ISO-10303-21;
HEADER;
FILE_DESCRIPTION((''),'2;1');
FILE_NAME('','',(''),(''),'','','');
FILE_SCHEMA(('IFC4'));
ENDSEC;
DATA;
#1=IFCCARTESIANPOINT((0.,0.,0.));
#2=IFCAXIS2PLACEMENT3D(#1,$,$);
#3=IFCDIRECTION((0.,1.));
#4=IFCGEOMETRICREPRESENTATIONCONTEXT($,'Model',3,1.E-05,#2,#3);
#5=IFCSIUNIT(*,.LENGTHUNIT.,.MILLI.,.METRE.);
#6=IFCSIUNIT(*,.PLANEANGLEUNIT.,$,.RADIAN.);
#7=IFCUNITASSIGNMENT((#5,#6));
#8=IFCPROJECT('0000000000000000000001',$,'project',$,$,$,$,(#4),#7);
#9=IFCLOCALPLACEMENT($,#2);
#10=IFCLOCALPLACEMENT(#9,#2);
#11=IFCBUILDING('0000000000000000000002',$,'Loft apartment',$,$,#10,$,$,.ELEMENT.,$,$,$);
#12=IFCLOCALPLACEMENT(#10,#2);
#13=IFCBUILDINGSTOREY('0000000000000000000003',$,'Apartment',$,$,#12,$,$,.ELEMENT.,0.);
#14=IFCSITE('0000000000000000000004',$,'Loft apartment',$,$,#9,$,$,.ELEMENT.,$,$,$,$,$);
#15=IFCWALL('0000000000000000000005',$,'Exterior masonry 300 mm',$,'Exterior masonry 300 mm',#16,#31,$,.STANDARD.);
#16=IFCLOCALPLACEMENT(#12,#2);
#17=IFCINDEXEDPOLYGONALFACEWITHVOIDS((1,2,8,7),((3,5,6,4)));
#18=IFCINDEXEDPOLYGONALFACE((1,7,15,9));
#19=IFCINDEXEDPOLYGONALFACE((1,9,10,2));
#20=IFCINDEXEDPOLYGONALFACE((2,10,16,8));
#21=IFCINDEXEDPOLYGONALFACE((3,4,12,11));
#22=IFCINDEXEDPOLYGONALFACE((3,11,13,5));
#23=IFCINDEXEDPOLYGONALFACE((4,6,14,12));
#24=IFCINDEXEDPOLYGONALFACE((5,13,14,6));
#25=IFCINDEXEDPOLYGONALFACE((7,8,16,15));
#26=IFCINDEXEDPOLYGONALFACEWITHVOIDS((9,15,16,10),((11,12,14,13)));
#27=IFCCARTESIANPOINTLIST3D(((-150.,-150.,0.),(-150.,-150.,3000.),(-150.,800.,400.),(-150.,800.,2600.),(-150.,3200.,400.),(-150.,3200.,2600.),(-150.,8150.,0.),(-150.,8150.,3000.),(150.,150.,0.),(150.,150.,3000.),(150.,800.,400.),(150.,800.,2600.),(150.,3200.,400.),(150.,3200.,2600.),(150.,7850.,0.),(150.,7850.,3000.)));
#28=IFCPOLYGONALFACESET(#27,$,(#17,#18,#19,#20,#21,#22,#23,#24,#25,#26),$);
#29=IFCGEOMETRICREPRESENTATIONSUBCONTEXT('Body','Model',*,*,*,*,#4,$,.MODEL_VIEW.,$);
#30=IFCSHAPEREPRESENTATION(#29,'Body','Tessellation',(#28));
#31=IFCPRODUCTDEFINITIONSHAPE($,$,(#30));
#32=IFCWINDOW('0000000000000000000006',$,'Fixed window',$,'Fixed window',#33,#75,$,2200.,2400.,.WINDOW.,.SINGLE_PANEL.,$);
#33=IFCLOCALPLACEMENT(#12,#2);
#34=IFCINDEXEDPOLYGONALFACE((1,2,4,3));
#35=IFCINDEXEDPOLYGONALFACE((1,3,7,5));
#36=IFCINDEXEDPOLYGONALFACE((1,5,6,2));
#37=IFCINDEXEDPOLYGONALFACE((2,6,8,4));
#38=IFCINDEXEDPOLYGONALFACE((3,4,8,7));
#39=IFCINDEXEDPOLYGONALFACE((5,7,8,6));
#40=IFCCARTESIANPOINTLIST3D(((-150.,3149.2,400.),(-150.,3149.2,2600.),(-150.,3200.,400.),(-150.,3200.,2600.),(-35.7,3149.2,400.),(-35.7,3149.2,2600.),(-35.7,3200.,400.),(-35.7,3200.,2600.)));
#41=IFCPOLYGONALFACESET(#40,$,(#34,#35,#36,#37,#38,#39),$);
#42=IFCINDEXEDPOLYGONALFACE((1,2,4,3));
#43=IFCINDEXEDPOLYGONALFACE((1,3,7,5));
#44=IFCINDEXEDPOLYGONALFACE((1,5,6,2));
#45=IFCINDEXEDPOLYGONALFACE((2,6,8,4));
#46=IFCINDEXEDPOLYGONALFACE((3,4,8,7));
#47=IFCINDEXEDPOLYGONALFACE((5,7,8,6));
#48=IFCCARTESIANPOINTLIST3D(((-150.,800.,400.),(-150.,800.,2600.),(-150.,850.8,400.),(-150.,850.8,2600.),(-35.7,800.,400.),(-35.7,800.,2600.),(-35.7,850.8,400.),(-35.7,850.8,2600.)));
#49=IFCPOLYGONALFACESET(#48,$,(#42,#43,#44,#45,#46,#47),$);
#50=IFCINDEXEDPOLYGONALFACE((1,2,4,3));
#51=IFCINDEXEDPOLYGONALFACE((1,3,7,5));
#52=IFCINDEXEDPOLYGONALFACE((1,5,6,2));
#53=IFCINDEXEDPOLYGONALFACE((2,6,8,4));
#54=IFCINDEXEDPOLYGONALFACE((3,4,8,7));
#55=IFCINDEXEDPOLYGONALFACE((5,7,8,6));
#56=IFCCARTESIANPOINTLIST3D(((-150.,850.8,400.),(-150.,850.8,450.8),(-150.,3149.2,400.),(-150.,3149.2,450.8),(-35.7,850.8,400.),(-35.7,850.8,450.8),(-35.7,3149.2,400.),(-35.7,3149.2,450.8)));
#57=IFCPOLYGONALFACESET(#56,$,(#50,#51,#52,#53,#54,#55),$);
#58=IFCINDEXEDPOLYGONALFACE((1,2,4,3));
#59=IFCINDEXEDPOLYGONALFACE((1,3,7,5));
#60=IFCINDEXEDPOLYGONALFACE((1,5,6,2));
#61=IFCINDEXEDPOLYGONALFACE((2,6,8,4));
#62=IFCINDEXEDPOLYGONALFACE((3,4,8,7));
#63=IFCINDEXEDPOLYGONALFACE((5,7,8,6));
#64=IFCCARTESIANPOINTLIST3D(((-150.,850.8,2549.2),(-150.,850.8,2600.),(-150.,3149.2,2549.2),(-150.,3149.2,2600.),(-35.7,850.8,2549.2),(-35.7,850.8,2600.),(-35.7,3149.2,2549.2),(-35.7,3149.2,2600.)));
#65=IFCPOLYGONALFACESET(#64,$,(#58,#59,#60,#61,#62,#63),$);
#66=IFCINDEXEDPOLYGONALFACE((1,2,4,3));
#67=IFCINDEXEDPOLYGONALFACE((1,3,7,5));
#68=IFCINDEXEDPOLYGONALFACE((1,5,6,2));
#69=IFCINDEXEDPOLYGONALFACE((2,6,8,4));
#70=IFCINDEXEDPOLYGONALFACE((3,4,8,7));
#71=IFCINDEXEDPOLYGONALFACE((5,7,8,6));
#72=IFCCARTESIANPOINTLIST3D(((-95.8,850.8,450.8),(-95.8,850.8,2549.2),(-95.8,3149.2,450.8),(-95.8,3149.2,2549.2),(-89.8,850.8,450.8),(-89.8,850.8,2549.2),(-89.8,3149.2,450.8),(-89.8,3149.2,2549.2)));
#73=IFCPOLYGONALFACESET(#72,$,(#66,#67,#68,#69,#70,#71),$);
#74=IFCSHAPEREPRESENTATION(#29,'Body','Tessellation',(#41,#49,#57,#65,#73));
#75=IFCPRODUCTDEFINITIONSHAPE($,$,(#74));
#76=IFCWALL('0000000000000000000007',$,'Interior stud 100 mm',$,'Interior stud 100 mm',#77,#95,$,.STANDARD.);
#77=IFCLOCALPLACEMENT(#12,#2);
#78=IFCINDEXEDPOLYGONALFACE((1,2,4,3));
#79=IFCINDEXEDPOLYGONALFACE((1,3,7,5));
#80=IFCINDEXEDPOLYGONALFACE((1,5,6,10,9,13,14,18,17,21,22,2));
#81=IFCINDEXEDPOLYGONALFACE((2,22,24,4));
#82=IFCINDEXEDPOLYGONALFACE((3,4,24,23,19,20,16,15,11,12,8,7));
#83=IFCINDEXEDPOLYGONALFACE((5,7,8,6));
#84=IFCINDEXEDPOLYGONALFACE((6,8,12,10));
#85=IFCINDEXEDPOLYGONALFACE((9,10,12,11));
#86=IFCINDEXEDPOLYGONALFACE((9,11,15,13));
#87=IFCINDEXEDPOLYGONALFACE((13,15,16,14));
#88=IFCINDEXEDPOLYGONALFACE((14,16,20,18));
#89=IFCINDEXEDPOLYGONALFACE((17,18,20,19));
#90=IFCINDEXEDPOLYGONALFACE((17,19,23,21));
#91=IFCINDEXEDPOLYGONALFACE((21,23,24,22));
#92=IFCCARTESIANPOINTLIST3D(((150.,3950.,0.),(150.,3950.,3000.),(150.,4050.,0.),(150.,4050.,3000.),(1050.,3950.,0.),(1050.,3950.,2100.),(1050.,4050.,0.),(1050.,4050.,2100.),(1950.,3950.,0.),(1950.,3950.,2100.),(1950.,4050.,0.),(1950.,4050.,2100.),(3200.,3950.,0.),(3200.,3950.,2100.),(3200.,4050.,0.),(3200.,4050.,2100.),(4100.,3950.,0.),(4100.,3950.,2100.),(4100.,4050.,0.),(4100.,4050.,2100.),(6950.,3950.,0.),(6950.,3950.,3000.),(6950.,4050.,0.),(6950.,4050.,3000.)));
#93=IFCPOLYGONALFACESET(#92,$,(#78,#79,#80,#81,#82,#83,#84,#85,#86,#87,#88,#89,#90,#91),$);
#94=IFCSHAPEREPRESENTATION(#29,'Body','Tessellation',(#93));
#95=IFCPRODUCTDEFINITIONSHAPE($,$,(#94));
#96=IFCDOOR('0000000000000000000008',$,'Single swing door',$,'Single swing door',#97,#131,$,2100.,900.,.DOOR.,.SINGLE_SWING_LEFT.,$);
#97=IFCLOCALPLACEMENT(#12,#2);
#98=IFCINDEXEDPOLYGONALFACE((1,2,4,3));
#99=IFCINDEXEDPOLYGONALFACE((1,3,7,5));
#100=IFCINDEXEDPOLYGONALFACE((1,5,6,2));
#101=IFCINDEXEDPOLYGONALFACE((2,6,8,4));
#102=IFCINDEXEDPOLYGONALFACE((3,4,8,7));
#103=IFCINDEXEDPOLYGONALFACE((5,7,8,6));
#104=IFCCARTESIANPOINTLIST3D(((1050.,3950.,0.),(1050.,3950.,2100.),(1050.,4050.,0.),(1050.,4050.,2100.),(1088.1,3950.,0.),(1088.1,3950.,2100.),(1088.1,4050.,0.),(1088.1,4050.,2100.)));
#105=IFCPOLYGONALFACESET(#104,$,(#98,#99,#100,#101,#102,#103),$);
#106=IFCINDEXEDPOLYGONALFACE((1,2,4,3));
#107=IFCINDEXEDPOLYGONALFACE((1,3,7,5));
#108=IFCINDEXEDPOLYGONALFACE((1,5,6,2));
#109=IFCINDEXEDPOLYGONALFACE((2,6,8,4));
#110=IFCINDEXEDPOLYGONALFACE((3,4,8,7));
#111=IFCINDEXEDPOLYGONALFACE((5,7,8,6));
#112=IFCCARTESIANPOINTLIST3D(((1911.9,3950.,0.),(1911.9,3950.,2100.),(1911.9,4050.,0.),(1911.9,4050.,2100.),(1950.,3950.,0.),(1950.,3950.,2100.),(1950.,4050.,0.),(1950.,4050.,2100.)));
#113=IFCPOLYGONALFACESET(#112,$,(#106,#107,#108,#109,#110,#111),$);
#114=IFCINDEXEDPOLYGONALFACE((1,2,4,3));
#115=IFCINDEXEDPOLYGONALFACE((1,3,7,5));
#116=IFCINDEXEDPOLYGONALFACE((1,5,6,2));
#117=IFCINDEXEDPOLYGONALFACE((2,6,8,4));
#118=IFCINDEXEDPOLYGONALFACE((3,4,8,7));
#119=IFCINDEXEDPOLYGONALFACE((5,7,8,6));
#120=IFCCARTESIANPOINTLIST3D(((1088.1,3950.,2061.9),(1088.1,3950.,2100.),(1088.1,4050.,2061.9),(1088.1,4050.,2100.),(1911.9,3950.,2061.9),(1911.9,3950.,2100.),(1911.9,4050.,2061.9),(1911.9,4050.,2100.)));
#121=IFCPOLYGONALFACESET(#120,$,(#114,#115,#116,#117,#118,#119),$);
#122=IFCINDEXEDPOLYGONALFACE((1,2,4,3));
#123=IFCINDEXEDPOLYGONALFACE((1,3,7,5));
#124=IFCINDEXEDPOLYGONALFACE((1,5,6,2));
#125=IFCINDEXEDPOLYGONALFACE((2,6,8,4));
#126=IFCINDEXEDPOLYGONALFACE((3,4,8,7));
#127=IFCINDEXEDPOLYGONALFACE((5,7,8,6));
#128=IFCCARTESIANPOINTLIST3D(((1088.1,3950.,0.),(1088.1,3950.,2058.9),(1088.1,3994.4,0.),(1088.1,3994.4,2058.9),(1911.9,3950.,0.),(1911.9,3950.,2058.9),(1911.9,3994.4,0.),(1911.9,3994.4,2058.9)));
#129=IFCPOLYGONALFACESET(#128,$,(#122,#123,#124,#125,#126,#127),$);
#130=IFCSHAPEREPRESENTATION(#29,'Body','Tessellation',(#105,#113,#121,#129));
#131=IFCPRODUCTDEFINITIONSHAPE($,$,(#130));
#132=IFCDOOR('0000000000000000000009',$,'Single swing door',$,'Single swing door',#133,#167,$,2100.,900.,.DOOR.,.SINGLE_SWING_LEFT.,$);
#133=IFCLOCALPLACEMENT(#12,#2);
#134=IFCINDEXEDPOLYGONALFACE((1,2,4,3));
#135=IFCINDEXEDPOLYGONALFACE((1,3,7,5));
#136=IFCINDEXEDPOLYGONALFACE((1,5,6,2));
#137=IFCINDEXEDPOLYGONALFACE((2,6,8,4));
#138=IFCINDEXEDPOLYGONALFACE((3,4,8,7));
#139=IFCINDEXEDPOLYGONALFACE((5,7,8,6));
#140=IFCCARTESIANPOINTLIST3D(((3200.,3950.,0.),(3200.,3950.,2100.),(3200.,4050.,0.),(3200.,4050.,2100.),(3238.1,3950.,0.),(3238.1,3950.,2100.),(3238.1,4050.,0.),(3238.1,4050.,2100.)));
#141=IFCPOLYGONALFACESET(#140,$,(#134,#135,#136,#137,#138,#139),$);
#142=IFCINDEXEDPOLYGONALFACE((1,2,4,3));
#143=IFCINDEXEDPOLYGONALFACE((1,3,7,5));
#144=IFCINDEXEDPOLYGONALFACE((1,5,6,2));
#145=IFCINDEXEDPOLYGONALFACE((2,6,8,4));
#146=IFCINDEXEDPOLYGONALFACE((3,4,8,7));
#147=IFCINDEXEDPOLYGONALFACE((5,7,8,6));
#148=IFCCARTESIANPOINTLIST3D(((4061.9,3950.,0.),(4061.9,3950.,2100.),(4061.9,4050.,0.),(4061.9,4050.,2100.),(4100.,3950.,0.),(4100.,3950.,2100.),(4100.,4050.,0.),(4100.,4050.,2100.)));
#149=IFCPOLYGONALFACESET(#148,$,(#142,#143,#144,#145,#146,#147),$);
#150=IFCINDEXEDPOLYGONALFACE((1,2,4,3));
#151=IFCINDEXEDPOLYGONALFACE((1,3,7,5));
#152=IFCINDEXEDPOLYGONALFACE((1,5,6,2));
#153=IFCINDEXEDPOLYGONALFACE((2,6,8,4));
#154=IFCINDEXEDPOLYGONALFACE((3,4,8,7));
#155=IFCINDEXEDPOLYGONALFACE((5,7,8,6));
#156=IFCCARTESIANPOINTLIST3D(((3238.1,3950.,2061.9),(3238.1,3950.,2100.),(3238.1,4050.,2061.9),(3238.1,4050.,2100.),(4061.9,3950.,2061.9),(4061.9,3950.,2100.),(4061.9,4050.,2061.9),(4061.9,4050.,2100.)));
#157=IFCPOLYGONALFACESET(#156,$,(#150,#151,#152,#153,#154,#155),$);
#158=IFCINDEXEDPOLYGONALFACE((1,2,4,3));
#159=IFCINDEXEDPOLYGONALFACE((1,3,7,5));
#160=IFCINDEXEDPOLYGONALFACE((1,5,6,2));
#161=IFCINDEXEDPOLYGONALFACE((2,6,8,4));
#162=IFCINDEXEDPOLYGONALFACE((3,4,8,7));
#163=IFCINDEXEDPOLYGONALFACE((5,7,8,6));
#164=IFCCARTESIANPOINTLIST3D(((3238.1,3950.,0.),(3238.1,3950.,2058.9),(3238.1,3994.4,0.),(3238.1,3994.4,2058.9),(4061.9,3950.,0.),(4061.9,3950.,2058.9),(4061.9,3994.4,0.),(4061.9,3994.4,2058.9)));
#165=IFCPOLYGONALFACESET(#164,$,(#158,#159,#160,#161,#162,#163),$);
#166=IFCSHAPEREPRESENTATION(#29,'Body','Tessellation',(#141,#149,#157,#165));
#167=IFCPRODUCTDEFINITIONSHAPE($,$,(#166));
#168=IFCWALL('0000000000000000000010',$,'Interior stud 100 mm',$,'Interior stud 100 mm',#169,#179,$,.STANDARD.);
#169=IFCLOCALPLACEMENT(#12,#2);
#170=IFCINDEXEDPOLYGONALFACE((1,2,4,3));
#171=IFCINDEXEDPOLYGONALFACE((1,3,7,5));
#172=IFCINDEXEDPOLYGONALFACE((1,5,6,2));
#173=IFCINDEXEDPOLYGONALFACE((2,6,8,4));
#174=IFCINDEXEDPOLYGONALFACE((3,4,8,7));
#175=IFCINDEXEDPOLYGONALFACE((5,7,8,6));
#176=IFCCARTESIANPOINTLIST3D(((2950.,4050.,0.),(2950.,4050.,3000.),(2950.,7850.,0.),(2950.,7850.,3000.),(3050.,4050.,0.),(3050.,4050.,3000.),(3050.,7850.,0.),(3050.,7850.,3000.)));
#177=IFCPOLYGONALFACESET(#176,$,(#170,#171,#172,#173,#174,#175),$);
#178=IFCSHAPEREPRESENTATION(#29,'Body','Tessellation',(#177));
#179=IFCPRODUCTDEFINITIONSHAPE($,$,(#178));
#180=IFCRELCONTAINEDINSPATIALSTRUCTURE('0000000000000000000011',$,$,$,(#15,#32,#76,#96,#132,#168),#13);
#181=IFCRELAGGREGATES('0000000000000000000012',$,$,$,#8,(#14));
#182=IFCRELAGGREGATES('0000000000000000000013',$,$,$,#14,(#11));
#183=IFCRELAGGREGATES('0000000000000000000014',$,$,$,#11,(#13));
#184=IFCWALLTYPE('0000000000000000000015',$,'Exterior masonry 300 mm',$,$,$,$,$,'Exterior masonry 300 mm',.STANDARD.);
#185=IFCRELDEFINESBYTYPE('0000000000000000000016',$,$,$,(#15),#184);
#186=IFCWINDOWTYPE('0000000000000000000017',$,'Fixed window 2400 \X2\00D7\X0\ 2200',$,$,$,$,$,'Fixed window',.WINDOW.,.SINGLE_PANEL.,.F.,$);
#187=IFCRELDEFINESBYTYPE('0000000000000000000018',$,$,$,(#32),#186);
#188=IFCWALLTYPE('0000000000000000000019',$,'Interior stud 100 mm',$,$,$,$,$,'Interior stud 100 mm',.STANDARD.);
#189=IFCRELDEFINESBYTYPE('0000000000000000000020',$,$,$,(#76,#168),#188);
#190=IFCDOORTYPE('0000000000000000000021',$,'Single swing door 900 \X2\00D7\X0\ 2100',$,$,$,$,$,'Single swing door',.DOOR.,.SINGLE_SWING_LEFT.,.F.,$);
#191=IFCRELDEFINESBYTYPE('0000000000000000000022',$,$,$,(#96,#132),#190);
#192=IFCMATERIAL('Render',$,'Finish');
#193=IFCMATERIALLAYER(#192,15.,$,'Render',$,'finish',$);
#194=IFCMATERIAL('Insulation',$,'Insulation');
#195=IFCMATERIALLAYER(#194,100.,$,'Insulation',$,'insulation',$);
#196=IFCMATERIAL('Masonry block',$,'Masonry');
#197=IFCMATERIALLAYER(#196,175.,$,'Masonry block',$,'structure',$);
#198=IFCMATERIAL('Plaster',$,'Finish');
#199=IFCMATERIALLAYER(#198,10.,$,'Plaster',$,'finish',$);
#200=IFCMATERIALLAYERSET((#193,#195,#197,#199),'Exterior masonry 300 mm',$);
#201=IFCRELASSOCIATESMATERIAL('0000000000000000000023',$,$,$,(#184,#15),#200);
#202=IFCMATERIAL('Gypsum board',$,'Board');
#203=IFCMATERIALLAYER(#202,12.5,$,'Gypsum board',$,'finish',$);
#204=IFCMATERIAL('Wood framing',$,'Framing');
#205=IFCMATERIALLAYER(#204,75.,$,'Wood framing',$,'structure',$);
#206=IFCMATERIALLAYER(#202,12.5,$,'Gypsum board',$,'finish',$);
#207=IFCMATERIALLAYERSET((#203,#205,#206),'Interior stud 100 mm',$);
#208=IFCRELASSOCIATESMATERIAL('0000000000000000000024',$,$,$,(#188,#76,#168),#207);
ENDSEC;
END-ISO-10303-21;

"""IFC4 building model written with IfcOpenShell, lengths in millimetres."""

from ifc_helpers import new_model, si_unit, direction, frame, origin, origin_with_axes, place, context, subcontext, project, spatial, polyline, outline, extrude, material, layer, layer_set, layer_usage, type_object, element, fill, save


model = new_model("IFC4")

# Units and contexts
model_context = context("Model", 3, precision=1e-05, world=origin(), true_north=direction((0.0, 1.0)))
body_context = subcontext(model_context, "Body", "Model", "MODEL_VIEW")
ifc_project = project(units=[si_unit("LENGTHUNIT", "METRE", prefix="MILLI"), si_unit("PLANEANGLEUNIT", "RADIAN")], contexts=[model_context])

# Site, building, storey
site_placement = place(None, origin())
site = spatial("IfcSite", under=ifc_project, at=site_placement, Name="Loft apartment", CompositionType="ELEMENT")
building_placement = place(site_placement, origin())
building = spatial("IfcBuilding", under=site, at=building_placement, Name="Loft apartment", CompositionType="ELEMENT")
storey_placement = place(building_placement, origin())
storey = spatial("IfcBuildingStorey", under=building, at=storey_placement, Name="Apartment", CompositionType="ELEMENT", Elevation=0.0)

# Shared definitions
ifc_material_1 = material(Name="Render", Category="Finish")
ifc_layer_1 = layer(ifc_material_1, 15.0, Name="Render", Category="finish")
ifc_material_2 = material(Name="Insulation", Category="Insulation")
ifc_layer_2 = layer(ifc_material_2, 100.0, Name="Insulation", Category="insulation")
ifc_material_3 = material(Name="Masonry block", Category="Masonry")
ifc_layer_3 = layer(ifc_material_3, 175.0, Name="Masonry block", Category="structure")
ifc_material_4 = material(Name="Plaster", Category="Finish")
ifc_layer_4 = layer(ifc_material_4, 10.0, Name="Plaster", Category="finish")
ifc_layer_set_1 = layer_set([ifc_layer_1, ifc_layer_2, ifc_layer_3, ifc_layer_4], Name="Exterior masonry 300 mm")
wall_type_1 = type_object("IfcWallType", Name="Exterior masonry 300 mm", ElementType="Exterior masonry 300 mm", PredefinedType="STANDARD", material=ifc_layer_set_1)

# Wall, opening, window
ifc_layer_usage_1 = layer_usage(ifc_layer_set_1, "AXIS2", "POSITIVE", -150.0)
wall_1_placement = place(storey_placement, frame((0.0, 8000.0, 0.0), z_axis=(0.0, 0.0, 1.0), x_axis=(0.0, -1.0, 0.0)))
wall_1 = element("IfcWall", 1, at=wall_1_placement, inside=storey, type_object=wall_type_1, material=ifc_layer_usage_1, Name="Exterior masonry 300 mm", ObjectType="Exterior masonry 300 mm", PredefinedType="STANDARD", context=body_context, shape_type="SweptSolid", body=[
    extrude(outline(polyline([(-150.0, -150.0), (8150.0, -150.0), (7850.0, 150.0), (150.0, 150.0), (-150.0, -150.0)])), origin(), (0.0, 0.0, 1.0), 3000.0),
])
opening_1_placement = place(wall_1_placement, frame((4800.0, 0.0, 400.0), z_axis=(0.0, 0.0, 1.0), x_axis=(1.0, 0.0, 0.0)))
opening_1 = element("IfcOpeningElement", 2, at=opening_1_placement, cuts=wall_1, PredefinedType="OPENING", context=body_context, shape_type="SweptSolid", body=[
    extrude(outline(polyline([(0.0, -160.0), (2400.0, -160.0), (2400.0, 160.0), (0.0, 160.0), (0.0, -160.0)])), origin(), (0.0, 0.0, 1.0), 2200.0),
])
window_type_1 = type_object("IfcWindowType", Name="Fixed window 2400 × 2200", ElementType="Fixed window", ParameterTakesPrecedence=False, PartitioningType="SINGLE_PANEL", PredefinedType="WINDOW")
window_1_placement = place(opening_1_placement, origin_with_axes())
window_1 = element("IfcWindow", 3, at=window_1_placement, inside=storey, type_object=window_type_1, Name="Fixed window", ObjectType="Fixed window", OverallHeight=2200.0, OverallWidth=2400.0, PartitioningType="SINGLE_PANEL", PredefinedType="WINDOW", context=body_context, shape_type="SweptSolid", body=[
    extrude(outline(polyline([(0.0, -150.0), (50.8, -150.0), (50.8, -35.7), (0.0, -35.7), (0.0, -150.0)])), origin(), (0.0, 0.0, 1.0), 2200.0),
    extrude(outline(polyline([(2349.2, -150.0), (2400.0, -150.0), (2400.0, -35.7), (2349.2, -35.7), (2349.2, -150.0)])), origin(), (0.0, 0.0, 1.0), 2200.0),
    extrude(outline(polyline([(50.8, -150.0), (2349.2, -150.0), (2349.2, -35.7), (50.8, -35.7), (50.8, -150.0)])), origin(), (0.0, 0.0, 1.0), 50.8),
    extrude(outline(polyline([(50.8, -150.0), (2349.2, -150.0), (2349.2, -35.7), (50.8, -35.7), (50.8, -150.0)])), frame((0.0, 0.0, 2149.2)), (0.0, 0.0, 1.0), 50.8),
    extrude(outline(polyline([(50.8, -95.8), (2349.2, -95.8), (2349.2, -89.8), (50.8, -89.8), (50.8, -95.8)])), frame((0.0, 0.0, 50.8)), (0.0, 0.0, 1.0), 2098.4),
])
fill(opening_1, window_1)

# Wall, openings, doors
ifc_material_5 = material(Name="Gypsum board", Category="Board")
ifc_layer_5 = layer(ifc_material_5, 12.5, Name="Gypsum board", Category="finish")
ifc_material_6 = material(Name="Wood framing", Category="Framing")
ifc_layer_6 = layer(ifc_material_6, 75.0, Name="Wood framing", Category="structure")
ifc_layer_7 = layer(ifc_material_5, 12.5, Name="Gypsum board", Category="finish")
ifc_layer_set_2 = layer_set([ifc_layer_5, ifc_layer_6, ifc_layer_7], Name="Interior stud 100 mm")
ifc_layer_usage_2 = layer_usage(ifc_layer_set_2, "AXIS2", "NEGATIVE", 50.0)
wall_type_2 = type_object("IfcWallType", Name="Interior stud 100 mm", ElementType="Interior stud 100 mm", PredefinedType="STANDARD", material=ifc_layer_set_2)
wall_2_placement = place(storey_placement, frame((0.0, 4000.0, 0.0), z_axis=(0.0, 0.0, 1.0), x_axis=(1.0, 0.0, 0.0)))
wall_2 = element("IfcWall", 4, at=wall_2_placement, inside=storey, type_object=wall_type_2, material=ifc_layer_usage_2, Name="Interior stud 100 mm", ObjectType="Interior stud 100 mm", PredefinedType="STANDARD", context=body_context, shape_type="SweptSolid", body=[
    extrude(outline(polyline([(150.0, -50.0), (6950.0, -50.0), (6950.0, 50.0), (150.0, 50.0), (150.0, -50.0)])), origin(), (0.0, 0.0, 1.0), 3000.0),
])
opening_2_placement = place(wall_2_placement, frame((1050.0, 0.0, 0.0), z_axis=(0.0, 0.0, 1.0), x_axis=(1.0, 0.0, 0.0)))
opening_2 = element("IfcOpeningElement", 5, at=opening_2_placement, cuts=wall_2, PredefinedType="OPENING", context=body_context, shape_type="SweptSolid", body=[
    extrude(outline(polyline([(0.0, -60.0), (900.0, -60.0), (900.0, 60.0), (0.0, 60.0), (0.0, -60.0)])), origin(), (0.0, 0.0, 1.0), 2100.0),
])
opening_3_placement = place(wall_2_placement, frame((3200.0, 0.0, 0.0), z_axis=(0.0, 0.0, 1.0), x_axis=(1.0, 0.0, 0.0)))
opening_3 = element("IfcOpeningElement", 6, at=opening_3_placement, cuts=wall_2, PredefinedType="OPENING", context=body_context, shape_type="SweptSolid", body=[
    extrude(outline(polyline([(0.0, -60.0), (900.0, -60.0), (900.0, 60.0), (0.0, 60.0), (0.0, -60.0)])), origin(), (0.0, 0.0, 1.0), 2100.0),
])
door_type_1 = type_object("IfcDoorType", Name="Single swing door 900 × 2100", ElementType="Single swing door", OperationType="SINGLE_SWING_LEFT", ParameterTakesPrecedence=False, PredefinedType="DOOR")
door_1_placement = place(opening_2_placement, origin_with_axes())
door_1 = element("IfcDoor", 7, at=door_1_placement, inside=storey, type_object=door_type_1, Name="Single swing door", ObjectType="Single swing door", OperationType="SINGLE_SWING_LEFT", OverallHeight=2100.0, OverallWidth=900.0, PredefinedType="DOOR", context=body_context, shape_type="SweptSolid", body=[
    extrude(outline(polyline([(0.0, -50.0), (38.1, -50.0), (38.1, 50.0), (0.0, 50.0), (0.0, -50.0)])), origin(), (0.0, 0.0, 1.0), 2100.0),
    extrude(outline(polyline([(861.9, -50.0), (900.0, -50.0), (900.0, 50.0), (861.9, 50.0), (861.9, -50.0)])), origin(), (0.0, 0.0, 1.0), 2100.0),
    extrude(outline(polyline([(38.1, -50.0), (861.9, -50.0), (861.9, 50.0), (38.1, 50.0), (38.1, -50.0)])), frame((0.0, 0.0, 2061.9)), (0.0, 0.0, 1.0), 38.1),
    extrude(outline(polyline([(38.1, -50.0), (861.9, -50.0), (861.9, -5.5), (38.1, -5.5), (38.1, -50.0)])), origin(), (0.0, 0.0, 1.0), 2058.9),
])
fill(opening_2, door_1)
door_2_placement = place(opening_3_placement, origin_with_axes())
door_2 = element("IfcDoor", 8, at=door_2_placement, inside=storey, type_object=door_type_1, Name="Single swing door", ObjectType="Single swing door", OperationType="SINGLE_SWING_LEFT", OverallHeight=2100.0, OverallWidth=900.0, PredefinedType="DOOR", context=body_context, shape_type="SweptSolid", body=[
    extrude(outline(polyline([(0.0, -50.0), (38.1, -50.0), (38.1, 50.0), (0.0, 50.0), (0.0, -50.0)])), origin(), (0.0, 0.0, 1.0), 2100.0),
    extrude(outline(polyline([(861.9, -50.0), (900.0, -50.0), (900.0, 50.0), (861.9, 50.0), (861.9, -50.0)])), origin(), (0.0, 0.0, 1.0), 2100.0),
    extrude(outline(polyline([(38.1, -50.0), (861.9, -50.0), (861.9, 50.0), (38.1, 50.0), (38.1, -50.0)])), frame((0.0, 0.0, 2061.9)), (0.0, 0.0, 1.0), 38.1),
    extrude(outline(polyline([(38.1, -50.0), (861.9, -50.0), (861.9, -5.5), (38.1, -5.5), (38.1, -50.0)])), origin(), (0.0, 0.0, 1.0), 2058.9),
])
fill(opening_3, door_2)

# Wall
ifc_layer_usage_3 = layer_usage(ifc_layer_set_2, "AXIS2", "NEGATIVE", 50.0)
wall_3_placement = place(storey_placement, frame((3000.0, 4000.0, 0.0), z_axis=(0.0, 0.0, 1.0), x_axis=(0.0, 1.0, 0.0)))
element("IfcWall", 9, at=wall_3_placement, inside=storey, type_object=wall_type_2, material=ifc_layer_usage_3, Name="Interior stud 100 mm", ObjectType="Interior stud 100 mm", PredefinedType="STANDARD", context=body_context, shape_type="SweptSolid", body=[
    extrude(outline(polyline([(50.0, -50.0), (3850.0, -50.0), (3850.0, 50.0), (50.0, 50.0), (50.0, -50.0)])), origin(), (0.0, 0.0, 1.0), 3000.0),
])

save(model, "model.ifc")
